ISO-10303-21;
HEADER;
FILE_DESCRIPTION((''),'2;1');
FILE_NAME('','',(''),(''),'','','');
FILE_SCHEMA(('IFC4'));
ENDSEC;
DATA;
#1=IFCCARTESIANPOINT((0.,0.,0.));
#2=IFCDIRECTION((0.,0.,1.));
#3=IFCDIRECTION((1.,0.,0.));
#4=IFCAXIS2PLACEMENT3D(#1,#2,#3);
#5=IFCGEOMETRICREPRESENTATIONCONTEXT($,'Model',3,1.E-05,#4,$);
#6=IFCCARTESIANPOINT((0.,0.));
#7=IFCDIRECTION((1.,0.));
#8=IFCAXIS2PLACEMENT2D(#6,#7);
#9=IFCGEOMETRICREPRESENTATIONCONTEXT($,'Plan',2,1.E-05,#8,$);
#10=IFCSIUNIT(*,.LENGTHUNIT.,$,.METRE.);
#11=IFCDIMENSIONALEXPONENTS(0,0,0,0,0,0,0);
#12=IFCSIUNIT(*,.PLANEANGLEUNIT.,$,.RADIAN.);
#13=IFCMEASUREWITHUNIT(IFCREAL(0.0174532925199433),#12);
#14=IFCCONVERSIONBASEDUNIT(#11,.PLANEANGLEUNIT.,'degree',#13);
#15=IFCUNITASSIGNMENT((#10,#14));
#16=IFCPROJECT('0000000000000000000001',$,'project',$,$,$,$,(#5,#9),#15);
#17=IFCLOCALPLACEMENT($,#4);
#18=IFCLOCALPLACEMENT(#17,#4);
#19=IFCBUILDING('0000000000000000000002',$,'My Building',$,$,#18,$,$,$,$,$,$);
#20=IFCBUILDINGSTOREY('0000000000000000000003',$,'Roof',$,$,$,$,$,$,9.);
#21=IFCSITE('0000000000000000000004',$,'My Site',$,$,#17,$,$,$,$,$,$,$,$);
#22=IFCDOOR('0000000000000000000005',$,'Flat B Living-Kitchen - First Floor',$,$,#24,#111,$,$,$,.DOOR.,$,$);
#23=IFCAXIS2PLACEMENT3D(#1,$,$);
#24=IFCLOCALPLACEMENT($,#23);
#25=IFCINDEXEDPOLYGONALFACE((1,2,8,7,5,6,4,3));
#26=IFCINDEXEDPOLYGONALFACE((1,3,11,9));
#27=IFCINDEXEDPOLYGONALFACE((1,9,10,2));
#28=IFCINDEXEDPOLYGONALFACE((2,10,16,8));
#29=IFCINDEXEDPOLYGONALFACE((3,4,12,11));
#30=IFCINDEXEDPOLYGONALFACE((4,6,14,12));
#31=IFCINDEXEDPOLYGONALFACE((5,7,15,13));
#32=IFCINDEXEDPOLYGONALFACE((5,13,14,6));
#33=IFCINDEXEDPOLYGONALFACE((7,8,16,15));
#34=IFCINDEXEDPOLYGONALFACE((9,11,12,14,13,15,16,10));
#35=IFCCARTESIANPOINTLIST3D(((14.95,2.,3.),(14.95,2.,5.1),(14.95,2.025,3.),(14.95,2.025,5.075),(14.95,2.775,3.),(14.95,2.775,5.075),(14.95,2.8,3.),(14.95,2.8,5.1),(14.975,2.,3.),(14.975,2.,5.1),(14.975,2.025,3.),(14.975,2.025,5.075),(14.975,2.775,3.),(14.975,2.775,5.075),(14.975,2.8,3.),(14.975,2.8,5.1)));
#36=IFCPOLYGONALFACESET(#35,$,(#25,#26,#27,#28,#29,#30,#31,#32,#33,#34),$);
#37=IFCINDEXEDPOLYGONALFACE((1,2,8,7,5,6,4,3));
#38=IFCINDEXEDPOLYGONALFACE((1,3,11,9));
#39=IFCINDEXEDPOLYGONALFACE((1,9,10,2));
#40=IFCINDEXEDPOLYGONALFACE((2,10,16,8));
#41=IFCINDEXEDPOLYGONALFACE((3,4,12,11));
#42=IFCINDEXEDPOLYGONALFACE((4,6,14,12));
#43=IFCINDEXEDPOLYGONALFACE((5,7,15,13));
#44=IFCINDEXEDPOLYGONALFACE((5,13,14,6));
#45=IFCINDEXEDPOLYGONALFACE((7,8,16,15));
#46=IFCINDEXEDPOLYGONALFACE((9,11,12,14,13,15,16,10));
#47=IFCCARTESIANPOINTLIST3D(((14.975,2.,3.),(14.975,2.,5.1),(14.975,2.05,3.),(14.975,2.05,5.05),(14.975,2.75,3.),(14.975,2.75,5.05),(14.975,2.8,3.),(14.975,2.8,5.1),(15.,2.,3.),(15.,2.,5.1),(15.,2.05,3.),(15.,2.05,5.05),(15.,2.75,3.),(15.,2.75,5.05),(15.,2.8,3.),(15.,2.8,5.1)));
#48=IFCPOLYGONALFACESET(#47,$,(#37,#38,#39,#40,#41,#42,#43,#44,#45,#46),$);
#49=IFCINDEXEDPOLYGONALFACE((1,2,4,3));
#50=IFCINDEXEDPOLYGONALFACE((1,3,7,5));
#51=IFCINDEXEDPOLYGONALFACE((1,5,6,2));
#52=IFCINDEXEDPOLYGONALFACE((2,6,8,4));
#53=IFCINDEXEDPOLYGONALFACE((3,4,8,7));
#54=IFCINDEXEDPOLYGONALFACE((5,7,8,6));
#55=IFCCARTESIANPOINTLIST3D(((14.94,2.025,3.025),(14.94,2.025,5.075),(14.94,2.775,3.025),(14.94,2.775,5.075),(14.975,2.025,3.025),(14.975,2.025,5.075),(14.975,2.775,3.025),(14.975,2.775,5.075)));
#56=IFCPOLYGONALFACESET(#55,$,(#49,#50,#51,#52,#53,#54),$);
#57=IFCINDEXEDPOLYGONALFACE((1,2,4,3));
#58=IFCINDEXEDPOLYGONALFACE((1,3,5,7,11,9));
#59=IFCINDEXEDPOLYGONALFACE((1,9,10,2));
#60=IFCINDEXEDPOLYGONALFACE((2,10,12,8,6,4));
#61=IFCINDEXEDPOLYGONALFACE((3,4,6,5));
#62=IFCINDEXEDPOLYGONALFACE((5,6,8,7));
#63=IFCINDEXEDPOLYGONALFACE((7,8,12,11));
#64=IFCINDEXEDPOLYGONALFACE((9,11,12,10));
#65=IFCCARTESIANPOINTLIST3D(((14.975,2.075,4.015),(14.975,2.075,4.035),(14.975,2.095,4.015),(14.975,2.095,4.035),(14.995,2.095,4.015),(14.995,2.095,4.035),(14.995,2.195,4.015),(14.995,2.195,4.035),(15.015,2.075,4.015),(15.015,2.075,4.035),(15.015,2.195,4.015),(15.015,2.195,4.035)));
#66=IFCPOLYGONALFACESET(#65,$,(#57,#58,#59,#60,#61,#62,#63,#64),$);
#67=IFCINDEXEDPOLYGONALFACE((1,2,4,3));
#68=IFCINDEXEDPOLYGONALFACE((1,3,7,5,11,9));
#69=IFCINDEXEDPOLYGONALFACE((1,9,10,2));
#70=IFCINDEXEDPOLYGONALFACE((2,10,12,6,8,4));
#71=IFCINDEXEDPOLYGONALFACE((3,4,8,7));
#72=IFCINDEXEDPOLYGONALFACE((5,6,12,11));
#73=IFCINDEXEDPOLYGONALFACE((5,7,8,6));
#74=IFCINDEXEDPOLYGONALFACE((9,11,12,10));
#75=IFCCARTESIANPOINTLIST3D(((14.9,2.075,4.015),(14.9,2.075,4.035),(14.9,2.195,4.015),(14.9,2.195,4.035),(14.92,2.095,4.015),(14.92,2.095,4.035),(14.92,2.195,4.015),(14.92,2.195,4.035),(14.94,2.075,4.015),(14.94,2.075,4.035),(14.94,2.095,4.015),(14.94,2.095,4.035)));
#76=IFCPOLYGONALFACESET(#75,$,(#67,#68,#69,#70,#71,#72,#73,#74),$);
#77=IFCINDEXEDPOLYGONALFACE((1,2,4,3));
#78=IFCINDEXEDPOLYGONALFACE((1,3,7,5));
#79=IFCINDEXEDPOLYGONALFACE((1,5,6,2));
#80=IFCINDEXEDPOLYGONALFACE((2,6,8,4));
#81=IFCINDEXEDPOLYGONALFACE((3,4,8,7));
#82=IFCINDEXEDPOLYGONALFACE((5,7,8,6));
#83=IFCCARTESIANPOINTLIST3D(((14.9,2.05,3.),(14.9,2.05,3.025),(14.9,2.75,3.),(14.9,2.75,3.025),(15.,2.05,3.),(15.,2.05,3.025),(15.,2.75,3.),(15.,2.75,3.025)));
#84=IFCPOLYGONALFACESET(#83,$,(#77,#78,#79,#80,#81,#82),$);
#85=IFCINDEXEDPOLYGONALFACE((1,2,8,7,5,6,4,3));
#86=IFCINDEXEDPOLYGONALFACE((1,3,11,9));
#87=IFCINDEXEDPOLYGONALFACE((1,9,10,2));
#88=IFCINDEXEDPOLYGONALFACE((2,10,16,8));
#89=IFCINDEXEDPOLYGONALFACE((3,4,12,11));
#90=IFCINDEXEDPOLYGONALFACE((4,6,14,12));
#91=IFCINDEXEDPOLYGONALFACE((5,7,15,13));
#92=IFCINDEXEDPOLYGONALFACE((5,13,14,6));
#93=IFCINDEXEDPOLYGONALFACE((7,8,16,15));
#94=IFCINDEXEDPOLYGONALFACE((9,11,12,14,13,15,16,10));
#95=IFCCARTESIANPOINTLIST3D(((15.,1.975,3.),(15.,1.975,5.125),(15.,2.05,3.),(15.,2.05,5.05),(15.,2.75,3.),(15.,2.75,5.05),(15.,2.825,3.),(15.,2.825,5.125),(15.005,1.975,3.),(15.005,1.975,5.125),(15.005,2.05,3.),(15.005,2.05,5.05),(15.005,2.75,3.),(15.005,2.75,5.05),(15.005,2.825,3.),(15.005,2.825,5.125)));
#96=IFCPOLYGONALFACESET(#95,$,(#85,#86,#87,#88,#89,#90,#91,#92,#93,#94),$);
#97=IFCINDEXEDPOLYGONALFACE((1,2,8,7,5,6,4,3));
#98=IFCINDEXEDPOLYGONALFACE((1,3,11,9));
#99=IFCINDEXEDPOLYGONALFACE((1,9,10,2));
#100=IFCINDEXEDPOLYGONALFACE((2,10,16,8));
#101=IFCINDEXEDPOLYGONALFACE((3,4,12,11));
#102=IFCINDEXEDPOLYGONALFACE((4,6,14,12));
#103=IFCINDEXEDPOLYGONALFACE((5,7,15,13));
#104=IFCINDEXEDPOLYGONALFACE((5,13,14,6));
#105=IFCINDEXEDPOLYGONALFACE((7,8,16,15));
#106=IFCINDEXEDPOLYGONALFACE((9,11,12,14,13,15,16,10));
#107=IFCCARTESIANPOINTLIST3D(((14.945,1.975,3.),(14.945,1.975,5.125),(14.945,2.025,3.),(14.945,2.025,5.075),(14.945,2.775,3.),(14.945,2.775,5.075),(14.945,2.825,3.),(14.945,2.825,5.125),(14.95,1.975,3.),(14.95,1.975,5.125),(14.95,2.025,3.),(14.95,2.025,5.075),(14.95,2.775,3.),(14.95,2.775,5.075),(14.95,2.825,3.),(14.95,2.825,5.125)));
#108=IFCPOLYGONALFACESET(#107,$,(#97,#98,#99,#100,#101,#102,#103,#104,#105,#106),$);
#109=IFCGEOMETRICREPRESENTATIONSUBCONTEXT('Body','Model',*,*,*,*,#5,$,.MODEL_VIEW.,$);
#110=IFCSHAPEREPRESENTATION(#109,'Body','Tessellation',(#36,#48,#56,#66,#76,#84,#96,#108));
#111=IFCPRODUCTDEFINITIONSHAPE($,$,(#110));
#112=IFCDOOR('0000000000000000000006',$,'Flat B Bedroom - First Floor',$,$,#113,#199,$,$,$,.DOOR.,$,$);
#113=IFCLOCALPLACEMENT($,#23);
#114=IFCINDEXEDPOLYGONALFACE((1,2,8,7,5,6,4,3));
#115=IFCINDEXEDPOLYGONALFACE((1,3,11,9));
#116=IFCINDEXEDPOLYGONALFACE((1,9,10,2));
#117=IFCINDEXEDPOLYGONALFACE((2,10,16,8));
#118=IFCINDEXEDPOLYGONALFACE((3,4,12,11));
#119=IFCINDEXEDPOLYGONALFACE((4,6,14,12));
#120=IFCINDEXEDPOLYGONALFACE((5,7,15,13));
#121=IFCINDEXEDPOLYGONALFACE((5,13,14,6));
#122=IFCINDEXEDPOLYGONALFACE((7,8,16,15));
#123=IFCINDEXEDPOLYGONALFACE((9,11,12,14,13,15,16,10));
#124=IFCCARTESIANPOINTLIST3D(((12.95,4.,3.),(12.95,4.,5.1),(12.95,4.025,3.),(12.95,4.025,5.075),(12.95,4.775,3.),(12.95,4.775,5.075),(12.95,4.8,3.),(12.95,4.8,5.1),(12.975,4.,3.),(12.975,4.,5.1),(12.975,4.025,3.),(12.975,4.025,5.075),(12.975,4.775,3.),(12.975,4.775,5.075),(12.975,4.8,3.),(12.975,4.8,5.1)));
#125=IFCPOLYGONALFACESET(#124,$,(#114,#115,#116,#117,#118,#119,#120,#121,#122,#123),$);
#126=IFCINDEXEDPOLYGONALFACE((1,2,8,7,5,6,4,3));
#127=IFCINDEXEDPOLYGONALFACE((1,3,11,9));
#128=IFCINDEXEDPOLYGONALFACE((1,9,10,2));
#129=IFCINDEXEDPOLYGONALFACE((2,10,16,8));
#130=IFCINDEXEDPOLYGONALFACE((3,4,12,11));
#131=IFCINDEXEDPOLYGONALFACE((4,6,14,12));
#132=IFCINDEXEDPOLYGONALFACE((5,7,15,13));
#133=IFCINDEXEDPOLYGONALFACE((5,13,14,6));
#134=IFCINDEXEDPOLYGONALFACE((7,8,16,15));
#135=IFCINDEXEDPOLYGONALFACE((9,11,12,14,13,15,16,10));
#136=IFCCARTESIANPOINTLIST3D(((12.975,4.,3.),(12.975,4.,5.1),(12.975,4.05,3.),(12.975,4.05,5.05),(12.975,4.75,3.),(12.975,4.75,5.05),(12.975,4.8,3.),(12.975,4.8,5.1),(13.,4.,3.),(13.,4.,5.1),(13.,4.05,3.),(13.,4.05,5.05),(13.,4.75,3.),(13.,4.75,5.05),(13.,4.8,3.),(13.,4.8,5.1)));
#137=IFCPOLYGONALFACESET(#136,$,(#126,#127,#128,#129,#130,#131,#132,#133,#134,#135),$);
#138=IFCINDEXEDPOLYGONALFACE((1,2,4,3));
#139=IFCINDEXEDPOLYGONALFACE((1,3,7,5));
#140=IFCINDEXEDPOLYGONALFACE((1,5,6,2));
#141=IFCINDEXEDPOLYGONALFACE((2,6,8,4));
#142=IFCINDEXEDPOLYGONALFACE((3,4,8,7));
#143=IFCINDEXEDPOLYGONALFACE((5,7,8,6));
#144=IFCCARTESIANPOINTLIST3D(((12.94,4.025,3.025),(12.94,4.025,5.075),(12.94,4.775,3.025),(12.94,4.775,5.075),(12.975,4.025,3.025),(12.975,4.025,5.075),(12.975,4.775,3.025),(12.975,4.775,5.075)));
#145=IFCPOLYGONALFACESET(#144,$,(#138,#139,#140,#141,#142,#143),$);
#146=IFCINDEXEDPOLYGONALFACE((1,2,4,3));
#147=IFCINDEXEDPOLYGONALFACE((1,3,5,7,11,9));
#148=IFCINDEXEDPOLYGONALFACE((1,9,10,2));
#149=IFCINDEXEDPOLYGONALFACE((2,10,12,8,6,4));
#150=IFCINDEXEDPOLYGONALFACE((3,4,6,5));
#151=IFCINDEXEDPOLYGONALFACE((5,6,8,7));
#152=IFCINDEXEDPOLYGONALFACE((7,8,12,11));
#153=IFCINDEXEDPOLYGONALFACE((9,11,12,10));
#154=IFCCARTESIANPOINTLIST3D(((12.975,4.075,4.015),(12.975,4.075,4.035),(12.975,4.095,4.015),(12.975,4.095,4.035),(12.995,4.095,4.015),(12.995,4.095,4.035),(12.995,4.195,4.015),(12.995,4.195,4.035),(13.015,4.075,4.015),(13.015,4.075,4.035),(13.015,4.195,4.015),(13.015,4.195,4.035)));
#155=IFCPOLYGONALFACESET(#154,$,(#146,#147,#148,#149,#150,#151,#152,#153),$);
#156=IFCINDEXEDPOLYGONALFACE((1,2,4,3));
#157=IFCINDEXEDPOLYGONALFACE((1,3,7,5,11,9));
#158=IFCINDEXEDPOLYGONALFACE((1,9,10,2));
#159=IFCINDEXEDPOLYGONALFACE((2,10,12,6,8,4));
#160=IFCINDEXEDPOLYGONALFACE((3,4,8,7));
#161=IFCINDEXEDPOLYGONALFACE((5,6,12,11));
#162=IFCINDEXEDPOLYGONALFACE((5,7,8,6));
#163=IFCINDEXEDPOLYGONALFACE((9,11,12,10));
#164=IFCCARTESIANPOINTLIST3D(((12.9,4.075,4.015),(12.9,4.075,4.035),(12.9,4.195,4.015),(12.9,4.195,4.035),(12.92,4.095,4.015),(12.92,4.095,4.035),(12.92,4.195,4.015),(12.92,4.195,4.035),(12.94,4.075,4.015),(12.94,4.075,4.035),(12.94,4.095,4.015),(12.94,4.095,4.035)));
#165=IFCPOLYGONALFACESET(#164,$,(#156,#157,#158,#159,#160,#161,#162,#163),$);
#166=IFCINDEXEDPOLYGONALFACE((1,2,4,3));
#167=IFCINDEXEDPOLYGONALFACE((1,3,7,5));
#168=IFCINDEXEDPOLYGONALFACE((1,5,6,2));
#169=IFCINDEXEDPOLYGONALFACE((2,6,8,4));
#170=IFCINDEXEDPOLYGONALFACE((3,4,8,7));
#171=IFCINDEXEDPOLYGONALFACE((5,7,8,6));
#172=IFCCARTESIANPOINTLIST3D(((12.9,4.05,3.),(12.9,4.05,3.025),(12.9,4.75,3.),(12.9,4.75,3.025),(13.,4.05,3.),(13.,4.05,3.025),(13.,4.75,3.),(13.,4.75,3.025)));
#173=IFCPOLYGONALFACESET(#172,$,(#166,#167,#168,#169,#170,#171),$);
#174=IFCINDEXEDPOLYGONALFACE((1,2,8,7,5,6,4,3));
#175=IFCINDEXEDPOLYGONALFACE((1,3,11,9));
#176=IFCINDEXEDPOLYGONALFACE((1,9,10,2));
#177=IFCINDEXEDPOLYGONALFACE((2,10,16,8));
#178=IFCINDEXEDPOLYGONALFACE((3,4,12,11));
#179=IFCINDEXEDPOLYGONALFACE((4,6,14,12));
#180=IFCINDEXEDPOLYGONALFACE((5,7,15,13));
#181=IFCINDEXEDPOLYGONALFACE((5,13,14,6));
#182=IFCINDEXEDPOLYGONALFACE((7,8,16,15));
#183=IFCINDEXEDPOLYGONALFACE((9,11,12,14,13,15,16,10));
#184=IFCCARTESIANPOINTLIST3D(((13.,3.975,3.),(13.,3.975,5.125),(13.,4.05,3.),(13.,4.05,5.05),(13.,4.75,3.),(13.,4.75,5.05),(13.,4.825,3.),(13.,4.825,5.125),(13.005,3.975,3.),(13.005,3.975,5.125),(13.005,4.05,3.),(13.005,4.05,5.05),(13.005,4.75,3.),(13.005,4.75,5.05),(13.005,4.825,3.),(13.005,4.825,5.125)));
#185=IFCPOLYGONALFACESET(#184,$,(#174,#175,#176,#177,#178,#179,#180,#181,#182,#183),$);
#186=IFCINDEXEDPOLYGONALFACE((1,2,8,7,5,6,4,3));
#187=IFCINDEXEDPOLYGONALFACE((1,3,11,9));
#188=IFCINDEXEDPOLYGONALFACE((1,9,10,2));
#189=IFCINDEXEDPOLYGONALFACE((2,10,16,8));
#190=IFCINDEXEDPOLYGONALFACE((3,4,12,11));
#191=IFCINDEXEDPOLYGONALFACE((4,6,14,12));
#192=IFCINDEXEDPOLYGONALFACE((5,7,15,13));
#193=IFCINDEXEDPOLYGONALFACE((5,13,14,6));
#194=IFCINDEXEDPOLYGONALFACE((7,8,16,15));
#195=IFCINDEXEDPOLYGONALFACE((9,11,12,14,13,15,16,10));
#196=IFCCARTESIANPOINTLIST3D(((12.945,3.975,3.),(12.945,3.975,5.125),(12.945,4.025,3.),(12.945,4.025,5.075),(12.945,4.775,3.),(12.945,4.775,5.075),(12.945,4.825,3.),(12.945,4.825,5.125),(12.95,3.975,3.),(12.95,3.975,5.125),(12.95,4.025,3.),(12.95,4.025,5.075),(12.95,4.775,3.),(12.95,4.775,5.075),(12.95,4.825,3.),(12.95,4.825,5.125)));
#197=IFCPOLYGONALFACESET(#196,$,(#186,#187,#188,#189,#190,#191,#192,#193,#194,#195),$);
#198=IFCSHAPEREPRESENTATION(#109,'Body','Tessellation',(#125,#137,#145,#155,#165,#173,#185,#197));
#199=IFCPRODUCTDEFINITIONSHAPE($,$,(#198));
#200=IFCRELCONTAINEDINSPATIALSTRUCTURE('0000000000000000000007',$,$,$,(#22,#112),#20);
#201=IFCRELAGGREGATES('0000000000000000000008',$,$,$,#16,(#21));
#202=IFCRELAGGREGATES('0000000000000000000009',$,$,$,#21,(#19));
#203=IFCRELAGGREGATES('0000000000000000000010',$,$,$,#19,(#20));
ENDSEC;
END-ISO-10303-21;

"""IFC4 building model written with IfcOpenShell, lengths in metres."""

from ifc_helpers import new_model, entity, si_unit, converted_unit, frame, origin_with_axes, origin_2d_with_axis, place, context, subcontext, project, spatial, line, indexed_curve, outline, extrude, element, save


model = new_model("IFC4")

# Units and contexts
model_context = context("Model", 3, precision=1e-05, world=origin_with_axes())
plan_context = context("Plan", 2, precision=1e-05, world=origin_2d_with_axis())
body_context = subcontext(model_context, "Body", "Model", "MODEL_VIEW")
ifc_project = project(units=[si_unit("LENGTHUNIT", "METRE"), converted_unit("PLANEANGLEUNIT", "degree", entity("IfcReal", 0.0174532925199433), si_unit("PLANEANGLEUNIT", "RADIAN"), dimensions=[0, 0, 0, 0, 0, 0, 0])], contexts=[model_context, plan_context])

# Site, building, storey
site_placement = place(None, origin_with_axes())
site = spatial("IfcSite", under=ifc_project, at=site_placement, Name="My Site")
building_placement = place(site_placement, origin_with_axes())
building = spatial("IfcBuilding", under=site, at=building_placement, Name="My Building")
storey = spatial("IfcBuildingStorey", under=building, Name="Roof", Elevation=9.0)

# Doors
door_1_placement = place(None, frame((15.0, 2.0, 3.0), z_axis=(0.0, 0.0, 1.0), x_axis=(0.0, 1.0, 0.0)))
element("IfcDoor", 1, at=door_1_placement, inside=storey, Name="Flat B Living-Kitchen - First Floor", PredefinedType="DOOR", context=body_context, shape_type="SweptSolid", body=[
    extrude(outline(indexed_curve([(0.0, 0.0), (0.0, 2.1), (0.8, 2.1), (0.8, 0.0), (0.775, 0.0), (0.775, 2.075), (0.025, 2.075), (0.025, 0.0)], segments=[line(1, 2, 3, 4, 5, 6, 7, 8, 1)])), frame((0.0, 0.025, 0.0), z_axis=(0.0, -1.0, 0.0), x_axis=(1.0, 0.0, 0.0)), (0.0, 0.0, -1.0), 0.025),
    extrude(outline(indexed_curve([(0.0, 0.0), (0.0, 2.1), (0.8, 2.1), (0.8, 0.0), (0.75, 0.0), (0.75, 2.05), (0.05, 2.05), (0.05, 0.0)], segments=[line(1, 2, 3, 4, 5, 6, 7, 8, 1)])), frame((0.0, 0.0, 0.0), z_axis=(0.0, -1.0, 0.0), x_axis=(1.0, 0.0, 0.0)), (0.0, 0.0, -1.0), 0.025),
    extrude(outline(indexed_curve([(0.0, 0.0), (0.75, 0.0), (0.75, 0.035), (0.0, 0.035)], segments=[line(1, 2, 3, 4, 1)])), frame((0.025, 0.025, 0.025), z_axis=(0.0, 0.0, 1.0), x_axis=(1.0, 0.0, 0.0)), (0.0, 0.0, 1.0), 2.05),
    extrude(outline(indexed_curve([(0.0, 0.0), (0.0, -0.04), (0.12, -0.04), (0.12, -0.02), (0.02, -0.02), (0.02, 0.0)], segments=[line(1, 2, 3, 4, 5, 6, 1)])), frame((0.075, 0.025, 1.015), z_axis=(0.0, 0.0, 1.0), x_axis=(1.0, 0.0, 0.0)), (0.0, 0.0, 1.0), 0.02),
    extrude(outline(indexed_curve([(0.0, 0.0), (0.0, 0.04), (0.12, 0.04), (0.12, 0.02), (0.02, 0.02), (0.02, 0.0)], segments=[line(1, 2, 3, 4, 5, 6, 1)])), frame((0.075, 0.06, 1.015), z_axis=(0.0, 0.0, 1.0), x_axis=(1.0, 0.0, 0.0)), (0.0, 0.0, 1.0), 0.02),
    extrude(outline(indexed_curve([(0.0, 0.0), (0.7, 0.0), (0.7, 0.1), (0.0, 0.1)], segments=[line(1, 2, 3, 4, 1)])), frame((0.05, 0.0, 0.0), z_axis=(0.0, 0.0, 1.0), x_axis=(1.0, 0.0, 0.0)), (0.0, 0.0, 1.0), 0.025),
    extrude(outline(indexed_curve([(0.0, 0.0), (0.0, 2.125), (0.85, 2.125), (0.85, 0.0), (0.775, 0.0), (0.775, 2.05), (0.075, 2.05), (0.075, 0.0)], segments=[line(1, 2, 3, 4, 5, 6, 7, 8, 1)])), frame((-0.025, -0.005, 0.0), z_axis=(0.0, -1.0, 0.0), x_axis=(1.0, 0.0, 0.0)), (0.0, 0.0, -1.0), 0.005),
    extrude(outline(indexed_curve([(0.0, 0.0), (0.0, 2.125), (0.85, 2.125), (0.85, 0.0), (0.8, 0.0), (0.8, 2.075), (0.05, 2.075), (0.05, 0.0)], segments=[line(1, 2, 3, 4, 5, 6, 7, 8, 1)])), frame((-0.025, 0.05, 0.0), z_axis=(0.0, -1.0, 0.0), x_axis=(1.0, 0.0, 0.0)), (0.0, 0.0, -1.0), 0.005),
])
door_2_placement = place(None, frame((13.0, 4.0, 3.0), z_axis=(0.0, 0.0, 1.0), x_axis=(0.0, 1.0, 0.0)))
element("IfcDoor", 2, at=door_2_placement, inside=storey, Name="Flat B Bedroom - First Floor", PredefinedType="DOOR", context=body_context, shape_type="SweptSolid", body=[
    extrude(outline(indexed_curve([(0.0, 0.0), (0.0, 2.1), (0.8, 2.1), (0.8, 0.0), (0.775, 0.0), (0.775, 2.075), (0.025, 2.075), (0.025, 0.0)], segments=[line(1, 2, 3, 4, 5, 6, 7, 8, 1)])), frame((0.0, 0.025, 0.0), z_axis=(0.0, -1.0, 0.0), x_axis=(1.0, 0.0, 0.0)), (0.0, 0.0, -1.0), 0.025),
    extrude(outline(indexed_curve([(0.0, 0.0), (0.0, 2.1), (0.8, 2.1), (0.8, 0.0), (0.75, 0.0), (0.75, 2.05), (0.05, 2.05), (0.05, 0.0)], segments=[line(1, 2, 3, 4, 5, 6, 7, 8, 1)])), frame((0.0, 0.0, 0.0), z_axis=(0.0, -1.0, 0.0), x_axis=(1.0, 0.0, 0.0)), (0.0, 0.0, -1.0), 0.025),
    extrude(outline(indexed_curve([(0.0, 0.0), (0.75, 0.0), (0.75, 0.035), (0.0, 0.035)], segments=[line(1, 2, 3, 4, 1)])), frame((0.025, 0.025, 0.025), z_axis=(0.0, 0.0, 1.0), x_axis=(1.0, 0.0, 0.0)), (0.0, 0.0, 1.0), 2.05),
    extrude(outline(indexed_curve([(0.0, 0.0), (0.0, -0.04), (0.12, -0.04), (0.12, -0.02), (0.02, -0.02), (0.02, 0.0)], segments=[line(1, 2, 3, 4, 5, 6, 1)])), frame((0.075, 0.025, 1.015), z_axis=(0.0, 0.0, 1.0), x_axis=(1.0, 0.0, 0.0)), (0.0, 0.0, 1.0), 0.02),
    extrude(outline(indexed_curve([(0.0, 0.0), (0.0, 0.04), (0.12, 0.04), (0.12, 0.02), (0.02, 0.02), (0.02, 0.0)], segments=[line(1, 2, 3, 4, 5, 6, 1)])), frame((0.075, 0.06, 1.015), z_axis=(0.0, 0.0, 1.0), x_axis=(1.0, 0.0, 0.0)), (0.0, 0.0, 1.0), 0.02),
    extrude(outline(indexed_curve([(0.0, 0.0), (0.7, 0.0), (0.7, 0.1), (0.0, 0.1)], segments=[line(1, 2, 3, 4, 1)])), frame((0.05, 0.0, 0.0), z_axis=(0.0, 0.0, 1.0), x_axis=(1.0, 0.0, 0.0)), (0.0, 0.0, 1.0), 0.025),
    extrude(outline(indexed_curve([(0.0, 0.0), (0.0, 2.125), (0.85, 2.125), (0.85, 0.0), (0.775, 0.0), (0.775, 2.05), (0.075, 2.05), (0.075, 0.0)], segments=[line(1, 2, 3, 4, 5, 6, 7, 8, 1)])), frame((-0.025, -0.005, 0.0), z_axis=(0.0, -1.0, 0.0), x_axis=(1.0, 0.0, 0.0)), (0.0, 0.0, -1.0), 0.005),
    extrude(outline(indexed_curve([(0.0, 0.0), (0.0, 2.125), (0.85, 2.125), (0.85, 0.0), (0.8, 0.0), (0.8, 2.075), (0.05, 2.075), (0.05, 0.0)], segments=[line(1, 2, 3, 4, 5, 6, 7, 8, 1)])), frame((-0.025, 0.05, 0.0), z_axis=(0.0, -1.0, 0.0), x_axis=(1.0, 0.0, 0.0)), (0.0, 0.0, -1.0), 0.005),
])

save(model, "model.ifc")
